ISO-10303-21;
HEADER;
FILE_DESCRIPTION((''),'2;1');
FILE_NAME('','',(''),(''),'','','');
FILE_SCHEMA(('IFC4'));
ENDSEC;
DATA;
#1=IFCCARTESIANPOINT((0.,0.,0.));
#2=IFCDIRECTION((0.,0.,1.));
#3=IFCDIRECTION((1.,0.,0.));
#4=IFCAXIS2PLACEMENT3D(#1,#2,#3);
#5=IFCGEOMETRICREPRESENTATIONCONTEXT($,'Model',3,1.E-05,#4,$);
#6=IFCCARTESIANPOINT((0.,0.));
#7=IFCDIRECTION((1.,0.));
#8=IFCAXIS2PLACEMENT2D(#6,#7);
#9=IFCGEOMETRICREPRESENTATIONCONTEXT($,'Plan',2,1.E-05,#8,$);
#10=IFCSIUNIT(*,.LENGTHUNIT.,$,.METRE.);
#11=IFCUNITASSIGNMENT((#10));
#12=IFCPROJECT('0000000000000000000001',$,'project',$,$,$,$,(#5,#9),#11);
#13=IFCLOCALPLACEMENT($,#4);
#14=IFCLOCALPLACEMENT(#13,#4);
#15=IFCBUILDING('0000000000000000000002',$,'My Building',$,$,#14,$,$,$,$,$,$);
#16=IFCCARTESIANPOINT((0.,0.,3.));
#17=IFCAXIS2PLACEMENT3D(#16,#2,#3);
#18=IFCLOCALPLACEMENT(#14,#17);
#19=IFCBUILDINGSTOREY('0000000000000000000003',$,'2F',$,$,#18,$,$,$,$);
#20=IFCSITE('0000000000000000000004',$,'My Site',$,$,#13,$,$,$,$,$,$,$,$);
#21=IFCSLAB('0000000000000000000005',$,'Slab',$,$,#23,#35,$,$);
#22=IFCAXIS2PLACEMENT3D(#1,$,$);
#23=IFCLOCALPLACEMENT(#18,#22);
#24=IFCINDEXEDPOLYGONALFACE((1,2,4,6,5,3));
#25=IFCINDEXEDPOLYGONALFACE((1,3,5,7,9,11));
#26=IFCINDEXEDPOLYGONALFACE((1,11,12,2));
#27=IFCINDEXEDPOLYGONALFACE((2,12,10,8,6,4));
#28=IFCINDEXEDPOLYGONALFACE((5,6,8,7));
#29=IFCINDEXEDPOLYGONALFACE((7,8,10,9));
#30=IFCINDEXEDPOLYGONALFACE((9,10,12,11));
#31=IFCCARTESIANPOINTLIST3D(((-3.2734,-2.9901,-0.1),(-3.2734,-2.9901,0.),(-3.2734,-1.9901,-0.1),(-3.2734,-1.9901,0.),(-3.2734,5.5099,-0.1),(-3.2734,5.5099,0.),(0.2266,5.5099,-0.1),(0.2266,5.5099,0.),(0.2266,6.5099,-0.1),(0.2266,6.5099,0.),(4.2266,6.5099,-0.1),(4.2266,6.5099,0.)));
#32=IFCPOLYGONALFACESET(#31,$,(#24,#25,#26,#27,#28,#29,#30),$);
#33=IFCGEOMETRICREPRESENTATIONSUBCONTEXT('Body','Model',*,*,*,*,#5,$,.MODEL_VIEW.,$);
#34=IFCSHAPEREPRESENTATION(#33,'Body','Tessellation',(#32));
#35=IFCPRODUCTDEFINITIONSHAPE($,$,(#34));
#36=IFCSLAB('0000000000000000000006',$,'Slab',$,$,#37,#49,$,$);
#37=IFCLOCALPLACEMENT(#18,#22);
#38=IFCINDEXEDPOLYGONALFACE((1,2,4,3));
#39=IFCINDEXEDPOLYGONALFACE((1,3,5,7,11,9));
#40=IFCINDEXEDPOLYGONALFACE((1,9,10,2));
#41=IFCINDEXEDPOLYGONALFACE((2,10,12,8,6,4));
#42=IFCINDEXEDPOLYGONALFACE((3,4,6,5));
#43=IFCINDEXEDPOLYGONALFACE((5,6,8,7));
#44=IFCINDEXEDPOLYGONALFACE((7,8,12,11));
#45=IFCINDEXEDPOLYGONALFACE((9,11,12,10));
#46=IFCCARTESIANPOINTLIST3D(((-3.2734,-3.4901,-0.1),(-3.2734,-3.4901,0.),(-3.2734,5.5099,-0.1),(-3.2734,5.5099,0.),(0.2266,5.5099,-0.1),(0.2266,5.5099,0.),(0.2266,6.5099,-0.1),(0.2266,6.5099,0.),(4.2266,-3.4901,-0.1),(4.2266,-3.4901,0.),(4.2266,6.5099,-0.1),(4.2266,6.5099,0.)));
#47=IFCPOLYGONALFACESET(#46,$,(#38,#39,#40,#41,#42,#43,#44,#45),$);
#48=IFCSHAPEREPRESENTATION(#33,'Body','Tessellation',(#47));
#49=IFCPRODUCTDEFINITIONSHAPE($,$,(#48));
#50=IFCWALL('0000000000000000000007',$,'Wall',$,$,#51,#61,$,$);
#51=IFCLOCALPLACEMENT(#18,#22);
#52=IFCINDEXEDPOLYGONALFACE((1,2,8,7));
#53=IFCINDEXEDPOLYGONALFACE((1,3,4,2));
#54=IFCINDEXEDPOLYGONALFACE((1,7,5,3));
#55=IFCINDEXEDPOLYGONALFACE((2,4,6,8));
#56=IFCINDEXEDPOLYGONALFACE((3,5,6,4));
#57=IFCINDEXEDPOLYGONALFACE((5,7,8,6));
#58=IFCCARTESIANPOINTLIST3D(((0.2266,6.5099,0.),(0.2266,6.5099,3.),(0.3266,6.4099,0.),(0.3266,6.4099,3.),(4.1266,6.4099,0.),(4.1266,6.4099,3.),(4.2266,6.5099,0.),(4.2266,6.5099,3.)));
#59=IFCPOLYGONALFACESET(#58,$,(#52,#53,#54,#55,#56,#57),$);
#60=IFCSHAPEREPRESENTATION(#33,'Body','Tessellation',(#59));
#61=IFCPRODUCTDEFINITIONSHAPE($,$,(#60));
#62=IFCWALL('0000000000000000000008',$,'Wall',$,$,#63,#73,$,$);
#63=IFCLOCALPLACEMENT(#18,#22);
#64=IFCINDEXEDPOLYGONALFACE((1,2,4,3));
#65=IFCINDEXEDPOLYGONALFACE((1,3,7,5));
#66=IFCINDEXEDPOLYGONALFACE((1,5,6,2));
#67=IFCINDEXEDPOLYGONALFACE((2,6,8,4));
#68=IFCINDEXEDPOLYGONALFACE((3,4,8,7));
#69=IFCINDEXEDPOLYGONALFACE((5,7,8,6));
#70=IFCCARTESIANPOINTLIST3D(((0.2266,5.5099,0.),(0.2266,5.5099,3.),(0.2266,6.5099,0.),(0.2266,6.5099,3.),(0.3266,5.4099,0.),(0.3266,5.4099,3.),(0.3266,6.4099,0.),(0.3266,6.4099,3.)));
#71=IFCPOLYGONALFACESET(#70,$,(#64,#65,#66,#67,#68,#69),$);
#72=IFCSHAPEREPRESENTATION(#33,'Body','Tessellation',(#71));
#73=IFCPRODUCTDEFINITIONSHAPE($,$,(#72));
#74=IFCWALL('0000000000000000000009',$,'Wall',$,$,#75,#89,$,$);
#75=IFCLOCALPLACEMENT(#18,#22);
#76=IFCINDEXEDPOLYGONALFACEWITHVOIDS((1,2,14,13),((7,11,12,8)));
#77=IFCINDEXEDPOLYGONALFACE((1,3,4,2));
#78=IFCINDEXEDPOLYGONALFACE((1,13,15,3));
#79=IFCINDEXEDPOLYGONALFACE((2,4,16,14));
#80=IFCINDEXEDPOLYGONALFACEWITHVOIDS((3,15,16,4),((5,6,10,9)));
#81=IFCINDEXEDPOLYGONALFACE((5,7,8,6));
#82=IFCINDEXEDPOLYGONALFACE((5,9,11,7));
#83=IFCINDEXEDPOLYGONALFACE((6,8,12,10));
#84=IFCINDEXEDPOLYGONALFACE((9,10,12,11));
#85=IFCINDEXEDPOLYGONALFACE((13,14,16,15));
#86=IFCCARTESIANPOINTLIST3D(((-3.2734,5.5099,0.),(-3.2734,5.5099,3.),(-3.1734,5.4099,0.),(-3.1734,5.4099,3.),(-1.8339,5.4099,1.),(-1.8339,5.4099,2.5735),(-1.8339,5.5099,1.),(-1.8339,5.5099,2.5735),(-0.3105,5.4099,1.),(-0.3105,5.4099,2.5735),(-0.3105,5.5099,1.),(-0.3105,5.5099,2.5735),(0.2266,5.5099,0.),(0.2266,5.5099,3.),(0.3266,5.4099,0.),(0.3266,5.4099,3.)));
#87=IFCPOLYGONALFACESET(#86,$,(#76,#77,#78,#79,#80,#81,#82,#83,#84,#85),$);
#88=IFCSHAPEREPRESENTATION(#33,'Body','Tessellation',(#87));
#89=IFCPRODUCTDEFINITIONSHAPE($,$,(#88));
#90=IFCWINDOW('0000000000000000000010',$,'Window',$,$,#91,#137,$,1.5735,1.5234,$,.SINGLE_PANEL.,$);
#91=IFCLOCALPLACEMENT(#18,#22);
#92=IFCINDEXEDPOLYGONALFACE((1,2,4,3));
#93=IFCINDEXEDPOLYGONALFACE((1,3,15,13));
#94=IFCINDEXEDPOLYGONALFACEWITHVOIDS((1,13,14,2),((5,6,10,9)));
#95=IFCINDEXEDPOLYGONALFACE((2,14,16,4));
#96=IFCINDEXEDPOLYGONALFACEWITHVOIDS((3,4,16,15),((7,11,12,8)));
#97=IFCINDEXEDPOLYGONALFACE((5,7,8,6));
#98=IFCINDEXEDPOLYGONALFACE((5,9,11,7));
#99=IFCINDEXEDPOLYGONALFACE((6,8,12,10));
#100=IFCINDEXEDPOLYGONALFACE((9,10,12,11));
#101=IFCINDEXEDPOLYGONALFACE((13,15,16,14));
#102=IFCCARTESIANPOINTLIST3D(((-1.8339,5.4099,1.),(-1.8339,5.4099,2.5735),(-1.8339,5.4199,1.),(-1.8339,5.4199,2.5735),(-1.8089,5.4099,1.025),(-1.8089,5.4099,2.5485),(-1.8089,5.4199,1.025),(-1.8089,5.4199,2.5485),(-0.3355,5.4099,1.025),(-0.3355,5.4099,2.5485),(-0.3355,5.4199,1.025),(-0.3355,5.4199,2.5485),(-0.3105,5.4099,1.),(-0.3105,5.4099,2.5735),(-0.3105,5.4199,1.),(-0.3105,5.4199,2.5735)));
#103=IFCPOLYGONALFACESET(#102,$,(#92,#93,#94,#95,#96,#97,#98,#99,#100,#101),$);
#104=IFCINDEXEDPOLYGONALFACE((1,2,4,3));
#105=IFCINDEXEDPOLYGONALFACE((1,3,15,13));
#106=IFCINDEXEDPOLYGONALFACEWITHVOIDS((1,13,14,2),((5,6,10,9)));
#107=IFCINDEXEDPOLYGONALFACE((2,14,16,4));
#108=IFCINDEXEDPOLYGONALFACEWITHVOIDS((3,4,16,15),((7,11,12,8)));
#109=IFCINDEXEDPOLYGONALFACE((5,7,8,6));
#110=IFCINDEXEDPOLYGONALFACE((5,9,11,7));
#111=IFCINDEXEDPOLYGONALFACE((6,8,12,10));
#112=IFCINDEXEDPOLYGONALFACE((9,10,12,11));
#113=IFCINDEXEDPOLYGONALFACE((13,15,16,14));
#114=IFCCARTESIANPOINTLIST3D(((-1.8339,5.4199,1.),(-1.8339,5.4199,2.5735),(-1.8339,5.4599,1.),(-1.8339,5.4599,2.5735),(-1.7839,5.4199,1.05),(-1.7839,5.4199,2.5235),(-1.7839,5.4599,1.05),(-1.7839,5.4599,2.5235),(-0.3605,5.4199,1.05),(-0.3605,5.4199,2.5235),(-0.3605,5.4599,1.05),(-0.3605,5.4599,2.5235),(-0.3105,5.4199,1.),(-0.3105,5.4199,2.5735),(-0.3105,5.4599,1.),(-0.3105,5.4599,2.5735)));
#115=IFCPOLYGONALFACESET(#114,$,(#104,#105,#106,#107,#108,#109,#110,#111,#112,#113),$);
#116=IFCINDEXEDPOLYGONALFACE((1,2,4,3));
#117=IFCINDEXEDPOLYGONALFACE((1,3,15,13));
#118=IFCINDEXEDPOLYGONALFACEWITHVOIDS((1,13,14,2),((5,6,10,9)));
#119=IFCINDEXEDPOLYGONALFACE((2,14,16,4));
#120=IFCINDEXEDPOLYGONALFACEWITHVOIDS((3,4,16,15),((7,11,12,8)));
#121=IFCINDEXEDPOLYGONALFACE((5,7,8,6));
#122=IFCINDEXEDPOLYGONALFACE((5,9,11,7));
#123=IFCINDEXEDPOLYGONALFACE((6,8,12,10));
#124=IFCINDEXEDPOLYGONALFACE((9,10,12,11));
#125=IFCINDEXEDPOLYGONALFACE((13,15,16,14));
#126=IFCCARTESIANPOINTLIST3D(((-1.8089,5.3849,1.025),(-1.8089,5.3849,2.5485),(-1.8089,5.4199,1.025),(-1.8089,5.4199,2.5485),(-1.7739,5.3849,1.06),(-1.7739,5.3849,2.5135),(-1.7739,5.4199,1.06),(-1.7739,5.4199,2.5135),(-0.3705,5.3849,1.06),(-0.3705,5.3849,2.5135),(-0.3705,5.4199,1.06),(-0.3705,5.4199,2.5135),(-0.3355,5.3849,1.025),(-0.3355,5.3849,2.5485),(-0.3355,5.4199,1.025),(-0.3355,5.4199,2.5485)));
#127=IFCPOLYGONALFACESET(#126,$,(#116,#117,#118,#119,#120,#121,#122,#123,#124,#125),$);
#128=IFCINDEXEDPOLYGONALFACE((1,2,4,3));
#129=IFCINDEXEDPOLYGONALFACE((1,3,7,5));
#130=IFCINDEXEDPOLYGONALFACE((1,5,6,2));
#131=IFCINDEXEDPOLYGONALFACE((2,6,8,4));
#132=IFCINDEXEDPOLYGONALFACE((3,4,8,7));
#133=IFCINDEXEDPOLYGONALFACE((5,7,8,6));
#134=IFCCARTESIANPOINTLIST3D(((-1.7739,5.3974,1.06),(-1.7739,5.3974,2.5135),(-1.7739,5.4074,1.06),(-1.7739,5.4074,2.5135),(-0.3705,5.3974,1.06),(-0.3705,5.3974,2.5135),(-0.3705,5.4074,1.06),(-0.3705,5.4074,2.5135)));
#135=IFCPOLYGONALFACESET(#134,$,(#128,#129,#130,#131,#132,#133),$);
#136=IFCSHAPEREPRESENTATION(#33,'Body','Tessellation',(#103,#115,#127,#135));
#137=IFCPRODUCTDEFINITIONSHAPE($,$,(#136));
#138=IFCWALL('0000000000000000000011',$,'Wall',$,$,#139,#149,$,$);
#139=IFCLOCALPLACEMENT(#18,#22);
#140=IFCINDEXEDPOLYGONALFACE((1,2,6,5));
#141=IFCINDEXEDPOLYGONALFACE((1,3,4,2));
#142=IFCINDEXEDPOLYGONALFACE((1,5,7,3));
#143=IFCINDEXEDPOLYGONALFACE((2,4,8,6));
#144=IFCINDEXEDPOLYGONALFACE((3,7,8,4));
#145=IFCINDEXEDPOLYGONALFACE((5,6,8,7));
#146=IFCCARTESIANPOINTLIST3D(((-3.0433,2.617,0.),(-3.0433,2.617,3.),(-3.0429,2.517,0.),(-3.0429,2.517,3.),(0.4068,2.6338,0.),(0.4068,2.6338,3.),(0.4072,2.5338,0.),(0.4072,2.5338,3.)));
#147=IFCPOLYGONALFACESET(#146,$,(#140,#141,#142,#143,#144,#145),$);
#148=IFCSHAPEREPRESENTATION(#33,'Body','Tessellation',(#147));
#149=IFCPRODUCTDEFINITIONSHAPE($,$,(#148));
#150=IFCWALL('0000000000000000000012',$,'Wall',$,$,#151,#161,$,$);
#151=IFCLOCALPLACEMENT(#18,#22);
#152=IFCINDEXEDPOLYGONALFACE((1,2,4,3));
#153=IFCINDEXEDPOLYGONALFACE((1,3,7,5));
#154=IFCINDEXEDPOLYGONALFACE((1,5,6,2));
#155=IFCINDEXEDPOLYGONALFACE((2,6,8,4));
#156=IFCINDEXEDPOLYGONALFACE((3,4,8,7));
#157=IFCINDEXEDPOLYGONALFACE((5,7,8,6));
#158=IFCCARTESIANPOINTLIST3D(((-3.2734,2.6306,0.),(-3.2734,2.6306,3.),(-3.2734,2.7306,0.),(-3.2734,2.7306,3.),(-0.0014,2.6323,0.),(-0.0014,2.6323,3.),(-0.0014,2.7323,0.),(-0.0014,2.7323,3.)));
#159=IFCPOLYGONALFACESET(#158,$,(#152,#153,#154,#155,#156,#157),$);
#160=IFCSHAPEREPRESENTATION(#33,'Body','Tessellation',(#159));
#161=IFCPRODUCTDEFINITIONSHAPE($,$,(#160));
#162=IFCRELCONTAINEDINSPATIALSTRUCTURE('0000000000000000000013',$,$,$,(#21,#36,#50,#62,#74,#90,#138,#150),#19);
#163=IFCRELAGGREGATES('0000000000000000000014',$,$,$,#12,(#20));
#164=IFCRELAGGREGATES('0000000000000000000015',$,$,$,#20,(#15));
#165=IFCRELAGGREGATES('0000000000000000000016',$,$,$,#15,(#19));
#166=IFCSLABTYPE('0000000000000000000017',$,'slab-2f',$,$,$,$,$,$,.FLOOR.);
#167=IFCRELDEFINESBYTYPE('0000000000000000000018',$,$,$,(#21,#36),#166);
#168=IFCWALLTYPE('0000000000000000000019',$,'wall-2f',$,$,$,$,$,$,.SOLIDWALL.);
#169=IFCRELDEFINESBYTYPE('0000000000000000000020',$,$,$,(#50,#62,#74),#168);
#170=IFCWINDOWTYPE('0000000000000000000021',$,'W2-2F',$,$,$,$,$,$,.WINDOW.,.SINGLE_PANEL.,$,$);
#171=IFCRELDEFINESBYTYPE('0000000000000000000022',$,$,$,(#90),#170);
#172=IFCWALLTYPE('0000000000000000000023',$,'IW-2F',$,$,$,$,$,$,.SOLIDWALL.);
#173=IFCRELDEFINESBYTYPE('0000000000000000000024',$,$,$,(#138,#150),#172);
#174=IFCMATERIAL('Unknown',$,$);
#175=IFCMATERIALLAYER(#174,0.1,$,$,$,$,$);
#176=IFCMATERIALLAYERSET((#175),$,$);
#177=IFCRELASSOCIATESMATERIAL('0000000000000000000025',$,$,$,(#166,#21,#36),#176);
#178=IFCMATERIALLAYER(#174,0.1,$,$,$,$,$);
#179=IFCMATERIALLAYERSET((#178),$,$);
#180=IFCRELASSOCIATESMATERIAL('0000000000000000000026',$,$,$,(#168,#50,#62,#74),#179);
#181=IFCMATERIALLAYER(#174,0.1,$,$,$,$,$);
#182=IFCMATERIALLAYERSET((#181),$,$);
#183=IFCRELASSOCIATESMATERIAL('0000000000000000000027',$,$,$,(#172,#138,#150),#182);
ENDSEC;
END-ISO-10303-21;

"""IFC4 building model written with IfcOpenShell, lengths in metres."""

from ifc_helpers import new_model, entity, si_unit, frame, origin_with_axes, origin_2d_with_axis, place, context, subcontext, project, spatial, line, indexed_curve, outline, extrude, shape, source, transform, mapped, material, layer, layer_set, layer_usage, type_object, type_shapes, element, fill, save


model = new_model("IFC4")

# Units and contexts
model_context = context("Model", 3, precision=1e-05, world=origin_with_axes())
plan_context = context("Plan", 2, precision=1e-05, world=origin_2d_with_axis())
body_context_1 = subcontext(model_context, "Body", "Model", "MODEL_VIEW")
body_context_2 = subcontext(plan_context, "Body", "Plan", "PLAN_VIEW")
ifc_project = project(units=[si_unit("LENGTHUNIT", "METRE")], contexts=[model_context, plan_context])

# Site, building, storey
site_placement = place(None, origin_with_axes())
site = spatial("IfcSite", under=ifc_project, at=site_placement, Name="My Site")
building_placement = place(site_placement, origin_with_axes())
building = spatial("IfcBuilding", under=site, at=building_placement, Name="My Building")
storey_placement = place(building_placement, frame((0.0, 0.0, 3.0), z_axis=(0.0, 0.0, 1.0), x_axis=(1.0, 0.0, 0.0)))
storey = spatial("IfcBuildingStorey", under=building, at=storey_placement, Name="2F")

# Slabs
ifc_material = material(Name="Unknown")
ifc_layer_1 = layer(ifc_material, 0.1)
ifc_layer_set_1 = layer_set([ifc_layer_1])
ifc_layer_usage_1 = layer_usage(ifc_layer_set_1, "AXIS3", "POSITIVE", -0.1)
slab_type = type_object("IfcSlabType", Name="slab-2f", PredefinedType="FLOOR", material=ifc_layer_set_1)
slab_1_placement = place(storey_placement, frame((4.2266, 6.5099, 0.0), z_axis=(0.0, 0.0, 1.0), x_axis=(1.0, 0.0, 0.0)))
element("IfcSlab", 1, at=slab_1_placement, inside=storey, type_object=slab_type, material=ifc_layer_usage_1, Name="Slab", context=body_context_1, shape_type="SweptSolid", body=[
    extrude(outline(indexed_curve([(0.0, 0.0), (-4.0, 0.0), (-4.0, -1.0), (-7.5, -1.0), (-7.5, -8.5), (-7.5, -9.5), (0.0, 0.0)])), frame((0.0, 0.0, -0.1), z_axis=(0.0, 0.0, 1.0), x_axis=(1.0, 0.0, 0.0)), (0.0, 0.0, 1.0), 0.1),
])
ifc_layer_usage_2 = layer_usage(ifc_layer_set_1, "AXIS3", "POSITIVE", -0.1)
slab_2_placement = place(storey_placement, frame((4.2266, 6.5099, 0.0), z_axis=(0.0, 0.0, 1.0), x_axis=(1.0, 0.0, 0.0)))
element("IfcSlab", 2, at=slab_2_placement, inside=storey, type_object=slab_type, material=ifc_layer_usage_2, Name="Slab", context=body_context_1, shape_type="SweptSolid", body=[
    extrude(outline(indexed_curve([(0.0, 0.0), (-4.0, 0.0), (-4.0, -1.0), (-7.5, -1.0), (-7.5, -10.0), (0.0, -10.0), (0.0, 0.0)])), frame((0.0, 0.0, -0.1), z_axis=(0.0, 0.0, 1.0), x_axis=(1.0, 0.0, 0.0)), (0.0, 0.0, 1.0), 0.1),
])

# Walls
ifc_layer_2 = layer(ifc_material, 0.1)
ifc_layer_set_2 = layer_set([ifc_layer_2])
ifc_layer_usage_3 = layer_usage(ifc_layer_set_2, "AXIS2", "POSITIVE", 0.0)
wall_type_1 = type_object("IfcWallType", Name="wall-2f", PredefinedType="SOLIDWALL", material=ifc_layer_set_2)
wall_1_placement = place(storey_placement, frame((4.2266, 6.5099, 0.0), z_axis=(0.0, 0.0, 1.0), x_axis=(-1.0, 0.0, 0.0)))
element("IfcWall", 3, at=wall_1_placement, inside=storey, type_object=wall_type_1, material=ifc_layer_usage_3, Name="Wall", context=body_context_1, shape_type="SweptSolid", body=[
    extrude(outline(indexed_curve([(0.0, 0.0), (0.1, 0.1), (3.9, 0.1), (4.0, 0.0)], segments=[line(1, 2, 3, 4, 1)])), origin_with_axes(), (0.0, 0.0, 1.0), 3.0),
])
ifc_layer_usage_4 = layer_usage(ifc_layer_set_2, "AXIS2", "POSITIVE", 0.0)
wall_2_placement = place(storey_placement, frame((0.2266, 6.5099, 0.0), z_axis=(0.0, 0.0, 1.0), x_axis=(0.0, -1.0, 0.0)))
element("IfcWall", 4, at=wall_2_placement, inside=storey, type_object=wall_type_1, material=ifc_layer_usage_4, Name="Wall", context=body_context_1, shape_type="SweptSolid", body=[
    extrude(outline(indexed_curve([(0.0, 0.0), (0.1, 0.1), (1.1, 0.1), (1.0, 0.0)], segments=[line(1, 2, 3, 4, 1)])), origin_with_axes(), (0.0, 0.0, 1.0), 3.0),
])

# Wall, opening, window
ifc_layer_usage_5 = layer_usage(ifc_layer_set_2, "AXIS2", "POSITIVE", 0.0)
wall_3_placement = place(storey_placement, frame((0.2266, 5.5099, 0.0), z_axis=(0.0, 0.0, 1.0), x_axis=(-1.0, 0.0, 0.0)))
wall_3 = element("IfcWall", 5, at=wall_3_placement, inside=storey, type_object=wall_type_1, material=ifc_layer_usage_5, Name="Wall", context=body_context_1, shape_type="SweptSolid", body=[
    extrude(outline(indexed_curve([(0.0, 0.0), (-0.1, 0.1), (3.4, 0.1), (3.5, 0.0)], segments=[line(1, 2, 3, 4, 1)])), origin_with_axes(), (0.0, 0.0, 1.0), 3.0),
])
shared_shape_1 = source(origin_with_axes(), body_context_1, "Body", "SweptSolid", [
    extrude(outline(indexed_curve([(0.0, 0.0), (1.5234, 0.0), (1.5234, 1.5735), (0.0, 1.5735)], segments=[line(1, 2, 3, 4, 1)])), frame((0.0, -0.6, 0.0), z_axis=(0.0, -1.0, 0.0), x_axis=(1.0, 0.0, 0.0)), (0.0, 0.0, -1.0), 1.2),
])
opening_1_placement = place(wall_3_placement, frame((0.5371, 0.0, 1.0), z_axis=(0.0, 0.0, 1.0), x_axis=(1.0, 0.0, 0.0)))
opening_1 = element("IfcOpeningElement", 6, at=opening_1_placement, cuts=wall_3, PredefinedType="OPENING", context=body_context_1, shape_type="MappedRepresentation", body=[
    mapped(shared_shape_1, transform((0.0, 0.0, 0.0), x_axis=(1.0, 0.0, 0.0), y_axis=(0.0, 1.0, 0.0), z_axis=(0.0, 0.0, 1.0), scale=1.0)),
])
window_type_1 = type_object("IfcWindowType", Name="W2-2F", PartitioningType="SINGLE_PANEL", PredefinedType="WINDOW")
shared_shape_2 = source(origin_with_axes(), body_context_1, "Body", "SweptSolid", [
    extrude(outline(indexed_curve([(0.0, 0.0), (1.5234, 0.0), (1.5234, 1.5735), (0.0, 1.5735)], segments=[line(1, 2, 3, 4, 1)]), holes=[indexed_curve([(0.025, 0.025), (1.4984, 0.025), (1.4984, 1.5485), (0.025, 1.5485)], segments=[line(1, 2, 3, 4, 1)])]), frame((0.0, 0.09, 0.0), z_axis=(0.0, -1.0, 0.0), x_axis=(1.0, 0.0, 0.0)), (0.0, 0.0, -1.0), 0.01),
    extrude(outline(indexed_curve([(0.0, 0.0), (1.5234, 0.0), (1.5234, 1.5735), (0.0, 1.5735)], segments=[line(1, 2, 3, 4, 1)]), holes=[indexed_curve([(0.05, 0.05), (1.4734, 0.05), (1.4734, 1.5235), (0.05, 1.5235)], segments=[line(1, 2, 3, 4, 1)])]), frame((0.0, 0.05, 0.0), z_axis=(0.0, -1.0, 0.0), x_axis=(1.0, 0.0, 0.0)), (0.0, 0.0, -1.0), 0.04),
    extrude(outline(indexed_curve([(0.0, 0.0), (1.4734, 0.0), (1.4734, 1.5235), (0.0, 1.5235)], segments=[line(1, 2, 3, 4, 1)]), holes=[indexed_curve([(0.035, 0.035), (1.4384, 0.035), (1.4384, 1.4885), (0.035, 1.4885)], segments=[line(1, 2, 3, 4, 1)])]), frame((0.025, 0.09, 0.025), z_axis=(0.0, -1.0, 0.0), x_axis=(1.0, 0.0, 0.0)), (0.0, 0.0, -1.0), 0.035),
    extrude(outline(indexed_curve([(0.035, 0.035), (1.4384, 0.035), (1.4384, 1.4885), (0.035, 1.4885)], segments=[line(1, 2, 3, 4, 1)])), frame((0.025, 0.1025, 0.025), z_axis=(0.0, -1.0, 0.0), x_axis=(1.0, 0.0, 0.0)), (0.0, 0.0, -1.0), 0.01),
])
shared_shape_3 = source(origin_with_axes(), body_context_2, "Body", "Curve2D", [
    entity("IfcIndexedPolyCurve", entity("IfcCartesianPointList2D", [[0.05, 0.05], [1.4734, 0.05]])),
    entity("IfcIndexedPolyCurve", entity("IfcCartesianPointList2D", [[0.0, 0.1], [0.025, 0.1], [0.025, 0.09], [0.05, 0.09], [0.05, 0.05], [0.0, 0.05]]), [entity("IfcLineIndex", [1, 2, 3, 4, 5, 6, 1])]),
    entity("IfcIndexedPolyCurve", entity("IfcCartesianPointList2D", [[1.5234, 0.1], [1.4984, 0.1], [1.4984, 0.09], [1.4734, 0.09], [1.4734, 0.05], [1.5234, 0.05]]), [entity("IfcLineIndex", [1, 2, 3, 4, 5, 6, 1])]),
    entity("IfcIndexedPolyCurve", entity("IfcCartesianPointList2D", [[0.025, 0.09], [0.06, 0.09], [0.06, 0.125], [0.025, 0.125]]), [entity("IfcLineIndex", [1, 2, 3, 4, 1])]),
    entity("IfcIndexedPolyCurve", entity("IfcCartesianPointList2D", [[1.4984, 0.09], [1.4634, 0.09], [1.4634, 0.125], [1.4984, 0.125]]), [entity("IfcLineIndex", [1, 2, 3, 4, 1])]),
    entity("IfcIndexedPolyCurve", entity("IfcCartesianPointList2D", [[0.06, 0.09], [1.4634, 0.09]])),
    entity("IfcIndexedPolyCurve", entity("IfcCartesianPointList2D", [[0.06, 0.125], [1.4634, 0.125]])),
    entity("IfcIndexedPolyCurve", entity("IfcCartesianPointList2D", [[0.06, 0.1075], [1.4634, 0.1075]])),
])
type_shapes(window_type_1, [shared_shape_2, shared_shape_3])
window_1_placement = place(opening_1_placement, frame((0.0, 0.0, 0.0), z_axis=(0.0, 0.0, 1.0), x_axis=(1.0, 0.0, 0.0)))
window_1 = element("IfcWindow", 7, at=window_1_placement, inside=storey, type_object=window_type_1, Name="Window", OverallHeight=1.5735, OverallWidth=1.5234, PartitioningType="SINGLE_PANEL", shapes=[
    shape(body_context_1, "Body", "MappedRepresentation", [mapped(shared_shape_2, transform((0.0, 0.0, 0.0), x_axis=(1.0, 0.0, 0.0), y_axis=(0.0, 1.0, 0.0), z_axis=(0.0, 0.0, 1.0), scale=1.0))]),
    shape(body_context_2, "Body", "MappedRepresentation", [mapped(shared_shape_3, transform((0.0, 0.0, 0.0), x_axis=(1.0, 0.0, 0.0), y_axis=(0.0, 1.0, 0.0), z_axis=(0.0, 0.0, 1.0), scale=1.0))]),
])
fill(opening_1, window_1)

# Walls
ifc_layer_3 = layer(ifc_material, 0.1)
ifc_layer_set_3 = layer_set([ifc_layer_3])
ifc_layer_usage_6 = layer_usage(ifc_layer_set_3, "AXIS2", "POSITIVE", 0.0)
wall_type_2 = type_object("IfcWallType", Name="IW-2F", PredefinedType="SOLIDWALL", material=ifc_layer_set_3)
wall_4_placement = place(storey_placement, frame((-3.0429, 2.517, 0.0), z_axis=(0.0, 0.0, 1.0), x_axis=(0.999988, 0.004854, 0.0)))
element("IfcWall", 8, at=wall_4_placement, inside=storey, type_object=wall_type_2, material=ifc_layer_usage_6, Name="Wall", context=body_context_1, shape_type="SweptSolid", body=[
    extrude(outline(indexed_curve([(0.0, 0.0), (0.0, 0.1), (3.4501, 0.1), (3.4501, 0.0)], segments=[line(1, 2, 3, 4, 1)])), origin_with_axes(), (0.0, 0.0, 1.0), 3.0),
])
ifc_layer_usage_7 = layer_usage(ifc_layer_set_3, "AXIS2", "POSITIVE", 0.0)
wall_5_placement = place(storey_placement, frame((-3.2734, 2.6306, 0.0), z_axis=(0.0, 0.0, 1.0), x_axis=(1.0, 0.000521, 0.0)))
element("IfcWall", 9, at=wall_5_placement, inside=storey, type_object=wall_type_2, material=ifc_layer_usage_7, Name="Wall", context=body_context_1, shape_type="SweptSolid", body=[
    extrude(outline(indexed_curve([(0.0, 0.0), (0.0, 0.1), (3.272, 0.1), (3.272, 0.0)], segments=[line(1, 2, 3, 4, 1)])), origin_with_axes(), (0.0, 0.0, 1.0), 3.0),
])

save(model, "model.ifc")
